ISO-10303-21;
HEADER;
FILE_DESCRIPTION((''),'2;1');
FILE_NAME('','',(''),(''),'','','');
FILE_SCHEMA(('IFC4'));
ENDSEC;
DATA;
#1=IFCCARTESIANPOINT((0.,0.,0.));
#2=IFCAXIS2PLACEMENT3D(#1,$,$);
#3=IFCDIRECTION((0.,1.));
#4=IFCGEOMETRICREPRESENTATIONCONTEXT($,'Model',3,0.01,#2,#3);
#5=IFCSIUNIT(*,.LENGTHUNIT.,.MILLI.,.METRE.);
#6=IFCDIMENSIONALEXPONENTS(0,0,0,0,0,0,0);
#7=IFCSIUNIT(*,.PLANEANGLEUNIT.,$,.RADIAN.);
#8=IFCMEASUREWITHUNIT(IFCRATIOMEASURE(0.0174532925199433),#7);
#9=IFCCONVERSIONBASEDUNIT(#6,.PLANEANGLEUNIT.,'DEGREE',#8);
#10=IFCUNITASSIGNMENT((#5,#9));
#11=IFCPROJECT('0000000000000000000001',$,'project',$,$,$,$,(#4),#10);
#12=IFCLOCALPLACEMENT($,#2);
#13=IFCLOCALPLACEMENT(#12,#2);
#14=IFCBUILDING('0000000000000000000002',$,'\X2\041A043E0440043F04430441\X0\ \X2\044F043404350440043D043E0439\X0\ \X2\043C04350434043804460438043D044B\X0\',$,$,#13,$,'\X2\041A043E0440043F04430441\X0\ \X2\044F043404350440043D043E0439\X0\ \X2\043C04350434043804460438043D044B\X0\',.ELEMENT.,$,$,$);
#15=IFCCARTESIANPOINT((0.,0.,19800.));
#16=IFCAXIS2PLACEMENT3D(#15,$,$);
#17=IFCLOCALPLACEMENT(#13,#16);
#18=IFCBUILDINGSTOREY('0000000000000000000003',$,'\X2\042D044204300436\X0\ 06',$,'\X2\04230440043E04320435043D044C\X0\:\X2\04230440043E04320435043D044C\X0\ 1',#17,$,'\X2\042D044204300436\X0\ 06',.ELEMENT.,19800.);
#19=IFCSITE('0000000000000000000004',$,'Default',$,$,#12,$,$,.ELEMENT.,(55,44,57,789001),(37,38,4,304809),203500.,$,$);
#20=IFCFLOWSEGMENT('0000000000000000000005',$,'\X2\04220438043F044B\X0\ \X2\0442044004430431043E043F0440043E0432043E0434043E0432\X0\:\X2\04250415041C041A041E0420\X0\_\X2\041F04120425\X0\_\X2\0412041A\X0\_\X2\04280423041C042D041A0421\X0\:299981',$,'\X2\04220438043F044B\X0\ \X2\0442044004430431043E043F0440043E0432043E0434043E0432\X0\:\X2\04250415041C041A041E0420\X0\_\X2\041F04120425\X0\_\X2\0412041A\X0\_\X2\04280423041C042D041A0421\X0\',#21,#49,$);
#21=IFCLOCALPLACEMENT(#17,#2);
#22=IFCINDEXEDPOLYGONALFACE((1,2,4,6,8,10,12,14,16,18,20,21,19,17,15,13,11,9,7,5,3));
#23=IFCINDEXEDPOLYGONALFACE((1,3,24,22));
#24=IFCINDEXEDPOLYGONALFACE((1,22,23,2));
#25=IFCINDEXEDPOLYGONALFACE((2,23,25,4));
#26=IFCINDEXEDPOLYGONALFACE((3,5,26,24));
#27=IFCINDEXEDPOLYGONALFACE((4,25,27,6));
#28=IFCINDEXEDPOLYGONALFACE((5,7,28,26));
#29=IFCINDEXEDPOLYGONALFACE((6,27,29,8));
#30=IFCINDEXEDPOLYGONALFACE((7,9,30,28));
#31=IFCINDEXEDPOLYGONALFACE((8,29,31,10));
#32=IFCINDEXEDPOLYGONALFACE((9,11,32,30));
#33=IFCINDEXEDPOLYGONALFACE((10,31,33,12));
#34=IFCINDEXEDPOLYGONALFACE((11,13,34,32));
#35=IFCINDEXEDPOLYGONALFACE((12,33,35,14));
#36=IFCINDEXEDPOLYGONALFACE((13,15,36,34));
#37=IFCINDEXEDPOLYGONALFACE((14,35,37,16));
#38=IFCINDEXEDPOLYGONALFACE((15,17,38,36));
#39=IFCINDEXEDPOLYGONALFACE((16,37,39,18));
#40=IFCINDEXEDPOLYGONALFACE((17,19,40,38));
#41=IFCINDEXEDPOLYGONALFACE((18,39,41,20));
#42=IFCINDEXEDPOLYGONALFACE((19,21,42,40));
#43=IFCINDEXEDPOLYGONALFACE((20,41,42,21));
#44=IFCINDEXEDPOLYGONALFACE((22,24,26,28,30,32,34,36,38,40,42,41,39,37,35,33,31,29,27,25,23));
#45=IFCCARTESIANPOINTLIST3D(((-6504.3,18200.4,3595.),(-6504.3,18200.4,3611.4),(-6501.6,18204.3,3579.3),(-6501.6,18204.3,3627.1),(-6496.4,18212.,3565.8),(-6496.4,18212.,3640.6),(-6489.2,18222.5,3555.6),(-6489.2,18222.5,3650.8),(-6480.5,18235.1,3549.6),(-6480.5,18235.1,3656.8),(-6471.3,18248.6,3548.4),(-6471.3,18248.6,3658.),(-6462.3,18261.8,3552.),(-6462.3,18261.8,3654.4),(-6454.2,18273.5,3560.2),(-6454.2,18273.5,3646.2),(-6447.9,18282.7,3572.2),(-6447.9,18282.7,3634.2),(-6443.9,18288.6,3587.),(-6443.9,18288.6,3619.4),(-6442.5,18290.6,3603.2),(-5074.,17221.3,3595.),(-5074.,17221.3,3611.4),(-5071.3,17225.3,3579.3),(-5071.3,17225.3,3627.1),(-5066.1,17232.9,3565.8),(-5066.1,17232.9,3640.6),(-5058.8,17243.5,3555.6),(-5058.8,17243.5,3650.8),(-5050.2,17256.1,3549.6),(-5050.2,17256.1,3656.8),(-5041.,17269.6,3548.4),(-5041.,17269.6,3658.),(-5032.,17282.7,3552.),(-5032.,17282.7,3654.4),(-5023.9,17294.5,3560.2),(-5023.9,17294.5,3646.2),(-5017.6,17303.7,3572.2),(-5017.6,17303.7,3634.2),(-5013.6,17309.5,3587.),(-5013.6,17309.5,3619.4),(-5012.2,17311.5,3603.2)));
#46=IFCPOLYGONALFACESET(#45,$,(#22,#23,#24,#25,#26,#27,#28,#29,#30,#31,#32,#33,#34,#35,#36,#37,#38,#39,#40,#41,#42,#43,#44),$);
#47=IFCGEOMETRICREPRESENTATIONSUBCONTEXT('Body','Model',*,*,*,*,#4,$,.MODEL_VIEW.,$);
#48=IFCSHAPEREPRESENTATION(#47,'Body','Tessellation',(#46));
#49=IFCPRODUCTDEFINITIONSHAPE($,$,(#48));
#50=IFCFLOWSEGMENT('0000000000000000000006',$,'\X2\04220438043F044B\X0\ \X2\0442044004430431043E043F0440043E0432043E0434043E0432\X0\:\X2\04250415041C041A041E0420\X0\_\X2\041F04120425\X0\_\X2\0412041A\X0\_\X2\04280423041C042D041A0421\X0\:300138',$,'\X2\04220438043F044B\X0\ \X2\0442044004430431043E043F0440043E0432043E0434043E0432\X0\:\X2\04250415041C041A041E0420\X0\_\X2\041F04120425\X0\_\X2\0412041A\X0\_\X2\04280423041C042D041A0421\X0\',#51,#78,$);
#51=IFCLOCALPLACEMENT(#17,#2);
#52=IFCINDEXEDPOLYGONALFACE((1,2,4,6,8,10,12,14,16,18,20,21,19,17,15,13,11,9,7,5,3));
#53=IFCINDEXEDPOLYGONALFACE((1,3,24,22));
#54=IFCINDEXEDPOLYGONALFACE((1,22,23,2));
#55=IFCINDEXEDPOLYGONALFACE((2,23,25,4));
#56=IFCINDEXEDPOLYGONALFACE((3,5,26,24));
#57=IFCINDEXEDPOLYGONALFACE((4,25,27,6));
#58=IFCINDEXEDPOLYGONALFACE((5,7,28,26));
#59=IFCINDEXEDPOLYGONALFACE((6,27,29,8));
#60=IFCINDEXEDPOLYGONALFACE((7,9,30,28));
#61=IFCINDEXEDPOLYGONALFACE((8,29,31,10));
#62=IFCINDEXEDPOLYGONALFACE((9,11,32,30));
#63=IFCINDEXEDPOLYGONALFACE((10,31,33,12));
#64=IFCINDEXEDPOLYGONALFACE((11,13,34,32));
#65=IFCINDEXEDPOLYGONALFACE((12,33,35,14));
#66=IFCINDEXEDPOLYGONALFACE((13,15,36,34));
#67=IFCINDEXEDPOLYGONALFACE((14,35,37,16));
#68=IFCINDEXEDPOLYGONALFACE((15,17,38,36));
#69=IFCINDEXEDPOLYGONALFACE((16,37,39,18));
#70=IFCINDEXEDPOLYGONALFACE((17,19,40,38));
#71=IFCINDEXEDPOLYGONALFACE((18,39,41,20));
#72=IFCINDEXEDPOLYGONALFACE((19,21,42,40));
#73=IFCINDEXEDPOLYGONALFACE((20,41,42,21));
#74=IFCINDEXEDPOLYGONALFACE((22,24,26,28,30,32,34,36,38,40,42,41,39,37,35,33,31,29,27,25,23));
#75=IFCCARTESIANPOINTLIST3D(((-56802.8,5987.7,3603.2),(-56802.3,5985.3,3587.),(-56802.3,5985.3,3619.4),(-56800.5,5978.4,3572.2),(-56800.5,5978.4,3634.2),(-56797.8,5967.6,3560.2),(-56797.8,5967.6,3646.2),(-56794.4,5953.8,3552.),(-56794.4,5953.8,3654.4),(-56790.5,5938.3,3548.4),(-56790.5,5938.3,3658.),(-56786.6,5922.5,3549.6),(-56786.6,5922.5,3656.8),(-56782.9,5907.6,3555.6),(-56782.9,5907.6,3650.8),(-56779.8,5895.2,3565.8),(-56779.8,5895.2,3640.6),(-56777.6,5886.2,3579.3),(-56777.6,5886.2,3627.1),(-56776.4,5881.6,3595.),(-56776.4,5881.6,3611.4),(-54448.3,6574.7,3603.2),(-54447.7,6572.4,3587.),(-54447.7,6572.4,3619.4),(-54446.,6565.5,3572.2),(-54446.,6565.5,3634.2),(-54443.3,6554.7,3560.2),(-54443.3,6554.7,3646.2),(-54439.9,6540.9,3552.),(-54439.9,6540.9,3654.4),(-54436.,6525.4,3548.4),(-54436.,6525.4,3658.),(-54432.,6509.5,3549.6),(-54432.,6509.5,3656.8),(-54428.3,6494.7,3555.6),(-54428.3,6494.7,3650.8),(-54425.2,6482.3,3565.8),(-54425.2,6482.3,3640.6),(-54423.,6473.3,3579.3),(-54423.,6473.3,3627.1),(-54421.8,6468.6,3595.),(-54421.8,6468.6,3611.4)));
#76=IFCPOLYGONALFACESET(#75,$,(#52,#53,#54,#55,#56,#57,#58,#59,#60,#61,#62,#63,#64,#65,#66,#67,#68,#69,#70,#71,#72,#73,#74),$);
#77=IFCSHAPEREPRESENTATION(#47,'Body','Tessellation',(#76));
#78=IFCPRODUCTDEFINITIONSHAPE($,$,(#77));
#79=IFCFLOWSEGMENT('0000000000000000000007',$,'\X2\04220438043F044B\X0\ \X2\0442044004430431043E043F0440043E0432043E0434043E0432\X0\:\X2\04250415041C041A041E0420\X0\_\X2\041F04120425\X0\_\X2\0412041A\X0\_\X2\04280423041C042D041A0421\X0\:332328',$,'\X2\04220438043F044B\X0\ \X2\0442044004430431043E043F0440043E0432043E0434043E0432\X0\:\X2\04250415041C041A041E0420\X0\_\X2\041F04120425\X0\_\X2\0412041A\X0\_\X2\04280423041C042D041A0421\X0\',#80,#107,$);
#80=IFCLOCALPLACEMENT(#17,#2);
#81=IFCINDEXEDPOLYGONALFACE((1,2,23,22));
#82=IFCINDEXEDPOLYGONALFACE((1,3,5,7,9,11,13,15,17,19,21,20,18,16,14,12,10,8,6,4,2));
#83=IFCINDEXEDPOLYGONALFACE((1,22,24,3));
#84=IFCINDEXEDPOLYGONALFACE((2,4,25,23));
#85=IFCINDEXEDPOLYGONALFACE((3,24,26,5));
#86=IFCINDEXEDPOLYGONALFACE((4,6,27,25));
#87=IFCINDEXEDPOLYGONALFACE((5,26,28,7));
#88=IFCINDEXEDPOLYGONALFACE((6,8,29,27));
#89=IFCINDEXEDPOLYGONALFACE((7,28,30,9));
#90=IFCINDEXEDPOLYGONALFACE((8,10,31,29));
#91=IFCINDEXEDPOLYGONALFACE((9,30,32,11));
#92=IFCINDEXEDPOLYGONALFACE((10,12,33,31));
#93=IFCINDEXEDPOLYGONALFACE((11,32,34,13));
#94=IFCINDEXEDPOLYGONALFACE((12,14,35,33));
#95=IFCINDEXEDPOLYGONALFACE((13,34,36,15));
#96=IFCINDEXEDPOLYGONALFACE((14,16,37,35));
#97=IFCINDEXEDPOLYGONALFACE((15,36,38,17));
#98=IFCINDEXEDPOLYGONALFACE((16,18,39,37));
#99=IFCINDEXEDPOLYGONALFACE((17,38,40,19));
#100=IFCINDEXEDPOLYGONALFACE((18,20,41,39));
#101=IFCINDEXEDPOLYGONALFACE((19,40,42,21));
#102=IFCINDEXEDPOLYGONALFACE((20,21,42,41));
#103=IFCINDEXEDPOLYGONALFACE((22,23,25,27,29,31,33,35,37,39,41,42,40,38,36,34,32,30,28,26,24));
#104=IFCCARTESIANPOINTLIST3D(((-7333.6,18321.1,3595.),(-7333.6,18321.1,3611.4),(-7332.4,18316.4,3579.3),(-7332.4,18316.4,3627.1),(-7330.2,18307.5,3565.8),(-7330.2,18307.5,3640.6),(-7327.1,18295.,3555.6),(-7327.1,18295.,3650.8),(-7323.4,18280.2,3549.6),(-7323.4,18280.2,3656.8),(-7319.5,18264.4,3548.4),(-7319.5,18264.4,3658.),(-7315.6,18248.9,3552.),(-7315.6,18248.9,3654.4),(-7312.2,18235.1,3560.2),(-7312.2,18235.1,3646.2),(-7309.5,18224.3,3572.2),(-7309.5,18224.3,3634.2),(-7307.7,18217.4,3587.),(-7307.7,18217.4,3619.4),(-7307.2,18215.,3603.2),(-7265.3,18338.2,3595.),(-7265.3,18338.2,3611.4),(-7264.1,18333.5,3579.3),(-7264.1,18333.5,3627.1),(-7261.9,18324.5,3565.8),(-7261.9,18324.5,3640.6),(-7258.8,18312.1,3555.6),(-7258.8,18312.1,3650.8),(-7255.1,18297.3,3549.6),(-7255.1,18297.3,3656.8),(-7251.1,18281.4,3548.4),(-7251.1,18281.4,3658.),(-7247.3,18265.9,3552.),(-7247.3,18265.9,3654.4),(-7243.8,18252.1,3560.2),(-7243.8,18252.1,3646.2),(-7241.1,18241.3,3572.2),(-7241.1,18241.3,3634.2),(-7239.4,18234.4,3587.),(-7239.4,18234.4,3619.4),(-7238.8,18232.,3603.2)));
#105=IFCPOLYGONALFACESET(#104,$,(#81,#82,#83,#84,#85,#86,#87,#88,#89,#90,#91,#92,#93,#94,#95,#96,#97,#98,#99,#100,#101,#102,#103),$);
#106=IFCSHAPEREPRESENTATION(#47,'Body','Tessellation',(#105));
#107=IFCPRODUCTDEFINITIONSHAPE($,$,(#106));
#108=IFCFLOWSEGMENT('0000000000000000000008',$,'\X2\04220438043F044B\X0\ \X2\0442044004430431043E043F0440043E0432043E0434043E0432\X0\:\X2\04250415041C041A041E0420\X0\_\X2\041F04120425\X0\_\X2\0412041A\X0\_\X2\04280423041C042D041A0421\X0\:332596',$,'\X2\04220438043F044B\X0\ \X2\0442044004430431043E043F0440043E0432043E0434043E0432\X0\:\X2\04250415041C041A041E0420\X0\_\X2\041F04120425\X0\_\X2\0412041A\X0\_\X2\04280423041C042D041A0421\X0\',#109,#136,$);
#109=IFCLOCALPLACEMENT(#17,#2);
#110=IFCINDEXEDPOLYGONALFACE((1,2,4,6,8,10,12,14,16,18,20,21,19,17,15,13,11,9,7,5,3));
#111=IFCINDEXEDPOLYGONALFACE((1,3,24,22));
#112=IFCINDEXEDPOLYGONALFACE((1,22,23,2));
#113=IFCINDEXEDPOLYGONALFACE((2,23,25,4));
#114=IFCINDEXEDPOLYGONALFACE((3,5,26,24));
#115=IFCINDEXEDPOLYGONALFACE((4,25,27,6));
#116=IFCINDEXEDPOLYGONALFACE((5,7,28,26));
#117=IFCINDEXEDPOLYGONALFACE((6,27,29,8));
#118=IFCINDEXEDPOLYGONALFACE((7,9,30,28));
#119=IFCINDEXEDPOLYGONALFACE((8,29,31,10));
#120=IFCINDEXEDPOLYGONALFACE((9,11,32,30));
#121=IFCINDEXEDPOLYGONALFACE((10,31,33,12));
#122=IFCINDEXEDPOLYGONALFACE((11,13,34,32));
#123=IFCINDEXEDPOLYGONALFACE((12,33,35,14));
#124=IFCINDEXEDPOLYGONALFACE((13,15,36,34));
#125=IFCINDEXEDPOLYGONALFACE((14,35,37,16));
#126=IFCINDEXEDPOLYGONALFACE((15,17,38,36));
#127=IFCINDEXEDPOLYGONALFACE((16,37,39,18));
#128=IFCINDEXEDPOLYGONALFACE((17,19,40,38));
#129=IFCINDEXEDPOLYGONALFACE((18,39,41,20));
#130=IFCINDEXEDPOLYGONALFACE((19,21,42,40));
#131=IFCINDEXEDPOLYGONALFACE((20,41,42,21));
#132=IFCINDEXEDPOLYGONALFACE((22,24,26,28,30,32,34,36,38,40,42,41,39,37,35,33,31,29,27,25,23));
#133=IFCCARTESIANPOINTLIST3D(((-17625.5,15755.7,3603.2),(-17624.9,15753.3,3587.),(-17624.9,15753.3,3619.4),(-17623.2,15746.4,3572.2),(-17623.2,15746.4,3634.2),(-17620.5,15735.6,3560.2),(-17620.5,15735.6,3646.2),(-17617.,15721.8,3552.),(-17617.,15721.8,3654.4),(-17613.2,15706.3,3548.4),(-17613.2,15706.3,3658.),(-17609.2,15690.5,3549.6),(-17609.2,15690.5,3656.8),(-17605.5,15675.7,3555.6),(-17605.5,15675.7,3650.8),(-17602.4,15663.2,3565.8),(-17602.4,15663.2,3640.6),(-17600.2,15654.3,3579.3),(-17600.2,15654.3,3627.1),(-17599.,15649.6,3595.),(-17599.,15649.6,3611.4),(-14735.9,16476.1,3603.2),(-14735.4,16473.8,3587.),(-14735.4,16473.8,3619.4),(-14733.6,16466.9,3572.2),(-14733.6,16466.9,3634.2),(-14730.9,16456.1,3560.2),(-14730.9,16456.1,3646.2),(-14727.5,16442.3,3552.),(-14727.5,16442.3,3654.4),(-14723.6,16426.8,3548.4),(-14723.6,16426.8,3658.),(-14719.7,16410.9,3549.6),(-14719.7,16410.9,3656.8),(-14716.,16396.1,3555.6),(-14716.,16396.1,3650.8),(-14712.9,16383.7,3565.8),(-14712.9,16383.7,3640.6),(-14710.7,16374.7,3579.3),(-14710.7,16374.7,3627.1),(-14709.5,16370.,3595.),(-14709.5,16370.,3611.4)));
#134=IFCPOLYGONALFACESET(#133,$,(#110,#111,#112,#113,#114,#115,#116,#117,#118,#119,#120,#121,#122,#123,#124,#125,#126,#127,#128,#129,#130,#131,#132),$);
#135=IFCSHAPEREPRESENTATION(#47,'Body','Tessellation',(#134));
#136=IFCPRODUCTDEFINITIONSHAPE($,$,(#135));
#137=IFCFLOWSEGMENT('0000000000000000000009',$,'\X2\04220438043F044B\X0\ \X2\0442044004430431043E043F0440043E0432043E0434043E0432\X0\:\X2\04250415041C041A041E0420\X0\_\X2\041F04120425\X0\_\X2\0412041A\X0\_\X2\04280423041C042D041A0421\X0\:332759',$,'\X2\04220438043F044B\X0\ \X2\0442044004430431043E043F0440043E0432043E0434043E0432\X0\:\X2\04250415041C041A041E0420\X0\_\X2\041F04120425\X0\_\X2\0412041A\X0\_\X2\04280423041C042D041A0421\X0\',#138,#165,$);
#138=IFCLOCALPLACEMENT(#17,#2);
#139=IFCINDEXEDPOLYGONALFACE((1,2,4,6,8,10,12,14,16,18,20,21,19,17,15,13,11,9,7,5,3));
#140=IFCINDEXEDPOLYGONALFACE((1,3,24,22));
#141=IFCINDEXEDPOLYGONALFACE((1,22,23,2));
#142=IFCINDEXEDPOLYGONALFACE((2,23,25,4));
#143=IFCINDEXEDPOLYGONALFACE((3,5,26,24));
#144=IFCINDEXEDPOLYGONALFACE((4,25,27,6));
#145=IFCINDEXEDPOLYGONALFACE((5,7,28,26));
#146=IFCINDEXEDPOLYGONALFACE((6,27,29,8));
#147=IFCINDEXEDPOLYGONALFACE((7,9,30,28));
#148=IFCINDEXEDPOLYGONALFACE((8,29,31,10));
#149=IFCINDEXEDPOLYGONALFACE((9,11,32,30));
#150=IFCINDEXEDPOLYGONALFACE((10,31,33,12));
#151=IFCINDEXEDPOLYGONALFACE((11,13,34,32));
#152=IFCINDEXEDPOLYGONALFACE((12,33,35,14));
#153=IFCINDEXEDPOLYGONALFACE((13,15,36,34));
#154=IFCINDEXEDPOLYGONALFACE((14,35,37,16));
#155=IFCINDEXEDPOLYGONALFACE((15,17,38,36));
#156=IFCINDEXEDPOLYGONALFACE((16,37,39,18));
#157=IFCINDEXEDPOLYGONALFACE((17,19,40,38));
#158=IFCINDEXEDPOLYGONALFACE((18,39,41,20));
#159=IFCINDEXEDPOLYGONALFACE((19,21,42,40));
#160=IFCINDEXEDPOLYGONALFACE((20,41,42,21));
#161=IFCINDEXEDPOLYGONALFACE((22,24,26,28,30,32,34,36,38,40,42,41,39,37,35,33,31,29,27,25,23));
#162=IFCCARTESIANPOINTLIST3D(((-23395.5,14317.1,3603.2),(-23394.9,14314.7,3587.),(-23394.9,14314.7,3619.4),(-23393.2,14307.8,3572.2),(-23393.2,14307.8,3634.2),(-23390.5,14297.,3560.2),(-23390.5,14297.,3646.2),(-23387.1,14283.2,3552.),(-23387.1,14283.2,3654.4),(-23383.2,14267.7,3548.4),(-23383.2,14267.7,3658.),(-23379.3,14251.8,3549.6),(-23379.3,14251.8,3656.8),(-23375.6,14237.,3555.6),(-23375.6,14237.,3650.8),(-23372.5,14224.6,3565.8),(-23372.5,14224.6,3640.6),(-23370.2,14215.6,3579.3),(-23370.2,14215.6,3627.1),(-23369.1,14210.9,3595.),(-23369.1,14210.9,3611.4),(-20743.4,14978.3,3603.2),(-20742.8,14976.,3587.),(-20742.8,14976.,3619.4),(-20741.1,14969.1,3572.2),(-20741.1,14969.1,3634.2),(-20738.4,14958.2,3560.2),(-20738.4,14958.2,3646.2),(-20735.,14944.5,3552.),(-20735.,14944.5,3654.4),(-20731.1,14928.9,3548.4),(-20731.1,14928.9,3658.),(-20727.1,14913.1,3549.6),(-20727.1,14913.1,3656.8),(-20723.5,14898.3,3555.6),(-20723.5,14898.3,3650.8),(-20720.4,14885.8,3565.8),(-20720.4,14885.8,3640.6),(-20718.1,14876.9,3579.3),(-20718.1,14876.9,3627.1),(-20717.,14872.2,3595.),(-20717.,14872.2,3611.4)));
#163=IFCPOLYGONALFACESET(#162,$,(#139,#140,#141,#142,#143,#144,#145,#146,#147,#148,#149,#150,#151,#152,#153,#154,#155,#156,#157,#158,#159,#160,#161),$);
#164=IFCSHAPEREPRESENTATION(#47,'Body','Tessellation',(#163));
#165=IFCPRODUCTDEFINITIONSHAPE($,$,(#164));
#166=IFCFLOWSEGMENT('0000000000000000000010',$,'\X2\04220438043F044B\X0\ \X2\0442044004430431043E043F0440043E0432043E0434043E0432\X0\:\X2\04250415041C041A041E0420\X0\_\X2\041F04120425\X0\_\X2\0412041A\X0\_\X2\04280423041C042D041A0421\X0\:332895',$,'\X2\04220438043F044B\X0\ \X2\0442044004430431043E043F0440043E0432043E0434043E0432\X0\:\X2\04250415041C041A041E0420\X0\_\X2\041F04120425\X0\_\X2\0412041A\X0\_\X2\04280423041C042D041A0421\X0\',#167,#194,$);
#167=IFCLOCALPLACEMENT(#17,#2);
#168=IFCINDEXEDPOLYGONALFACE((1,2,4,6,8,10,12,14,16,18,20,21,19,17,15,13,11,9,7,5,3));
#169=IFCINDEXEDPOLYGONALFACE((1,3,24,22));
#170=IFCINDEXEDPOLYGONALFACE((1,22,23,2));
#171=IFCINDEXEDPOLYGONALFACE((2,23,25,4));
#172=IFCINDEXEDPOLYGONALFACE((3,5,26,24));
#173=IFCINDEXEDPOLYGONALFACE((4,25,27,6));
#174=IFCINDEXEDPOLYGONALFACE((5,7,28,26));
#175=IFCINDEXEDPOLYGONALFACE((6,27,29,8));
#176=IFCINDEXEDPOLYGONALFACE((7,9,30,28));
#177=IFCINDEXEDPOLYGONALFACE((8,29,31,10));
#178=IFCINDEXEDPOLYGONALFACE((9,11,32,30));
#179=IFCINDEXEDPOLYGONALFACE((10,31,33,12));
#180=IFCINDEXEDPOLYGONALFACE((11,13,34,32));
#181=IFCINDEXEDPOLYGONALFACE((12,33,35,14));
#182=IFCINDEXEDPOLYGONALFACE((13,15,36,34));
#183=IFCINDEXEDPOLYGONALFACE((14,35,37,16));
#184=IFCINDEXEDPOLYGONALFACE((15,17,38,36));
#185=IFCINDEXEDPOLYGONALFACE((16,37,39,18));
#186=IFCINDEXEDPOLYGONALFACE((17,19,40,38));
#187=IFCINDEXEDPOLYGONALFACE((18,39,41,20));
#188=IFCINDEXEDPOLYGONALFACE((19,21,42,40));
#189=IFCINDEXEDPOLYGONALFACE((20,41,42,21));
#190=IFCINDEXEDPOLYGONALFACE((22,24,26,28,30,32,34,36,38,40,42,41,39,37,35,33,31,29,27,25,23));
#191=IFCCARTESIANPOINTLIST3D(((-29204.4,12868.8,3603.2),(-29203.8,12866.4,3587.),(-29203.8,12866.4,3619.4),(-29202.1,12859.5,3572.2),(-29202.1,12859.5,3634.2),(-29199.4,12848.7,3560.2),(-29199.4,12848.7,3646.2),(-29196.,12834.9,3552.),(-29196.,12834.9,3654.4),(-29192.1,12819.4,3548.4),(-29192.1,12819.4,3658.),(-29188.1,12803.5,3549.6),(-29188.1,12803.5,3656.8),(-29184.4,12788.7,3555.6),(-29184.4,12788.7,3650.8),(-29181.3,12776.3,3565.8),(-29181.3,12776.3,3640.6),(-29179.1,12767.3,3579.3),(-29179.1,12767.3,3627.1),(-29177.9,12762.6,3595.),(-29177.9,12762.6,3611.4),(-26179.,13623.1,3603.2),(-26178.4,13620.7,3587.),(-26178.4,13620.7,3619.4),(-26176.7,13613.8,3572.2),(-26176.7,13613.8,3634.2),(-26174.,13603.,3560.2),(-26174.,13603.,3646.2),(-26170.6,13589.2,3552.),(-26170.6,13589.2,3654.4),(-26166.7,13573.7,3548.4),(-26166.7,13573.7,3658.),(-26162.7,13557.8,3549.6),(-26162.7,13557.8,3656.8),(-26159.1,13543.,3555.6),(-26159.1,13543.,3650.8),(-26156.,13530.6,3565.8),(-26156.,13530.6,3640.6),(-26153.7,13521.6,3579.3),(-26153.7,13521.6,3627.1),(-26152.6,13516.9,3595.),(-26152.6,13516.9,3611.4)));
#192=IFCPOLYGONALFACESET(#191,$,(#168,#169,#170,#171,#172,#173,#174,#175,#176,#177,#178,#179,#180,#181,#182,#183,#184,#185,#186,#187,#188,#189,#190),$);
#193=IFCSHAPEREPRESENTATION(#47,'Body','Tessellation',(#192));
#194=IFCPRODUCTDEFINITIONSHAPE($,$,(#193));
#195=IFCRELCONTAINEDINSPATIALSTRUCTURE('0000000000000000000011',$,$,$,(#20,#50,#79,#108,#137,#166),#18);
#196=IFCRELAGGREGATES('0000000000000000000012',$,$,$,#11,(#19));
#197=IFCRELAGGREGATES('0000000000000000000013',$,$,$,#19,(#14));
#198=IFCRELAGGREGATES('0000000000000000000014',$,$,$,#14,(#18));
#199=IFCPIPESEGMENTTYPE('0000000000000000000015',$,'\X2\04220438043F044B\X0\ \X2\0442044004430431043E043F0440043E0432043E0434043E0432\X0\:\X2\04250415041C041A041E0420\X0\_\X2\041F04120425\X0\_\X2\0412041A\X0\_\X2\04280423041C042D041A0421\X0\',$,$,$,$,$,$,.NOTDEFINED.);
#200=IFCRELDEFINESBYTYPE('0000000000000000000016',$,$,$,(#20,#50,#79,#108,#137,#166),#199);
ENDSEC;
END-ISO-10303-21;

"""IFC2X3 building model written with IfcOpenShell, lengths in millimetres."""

from ifc_helpers import new_model, entity, si_unit, converted_unit, direction, frame, origin, origin_2d_with_axis, place, context, subcontext, project, spatial, circle, extrude, type_object, element, save


model = new_model("IFC2X3")

# Units and contexts
model_context = context("Model", 3, precision=0.01, world=origin(), true_north=direction((0.0, 1.0)))
body_context = subcontext(model_context, "Body", "Model", "MODEL_VIEW")
ifc_project = project(units=[si_unit("LENGTHUNIT", "METRE", prefix="MILLI"), converted_unit("PLANEANGLEUNIT", "DEGREE", entity("IfcRatioMeasure", 0.0174532925199433), si_unit("PLANEANGLEUNIT", "RADIAN"), dimensions=[0, 0, 0, 0, 0, 0, 0])], contexts=[model_context])

# Site, building, storey
site_placement = place(None, origin())
site = spatial("IfcSite", under=ifc_project, at=site_placement, Name="Default", CompositionType="ELEMENT", RefLatitude=(55, 44, 57, 789001), RefLongitude=(37, 38, 4, 304809), RefElevation=203500.0)
building_placement = place(site_placement, origin())
building = spatial("IfcBuilding", under=site, at=building_placement, Name="Корпус ядерной медицины", LongName="Корпус ядерной медицины", CompositionType="ELEMENT")
storey_placement = place(building_placement, frame((0.0, 0.0, 19800.0)))
storey = spatial("IfcBuildingStorey", under=building, at=storey_placement, Name="Этаж 06", ObjectType="Уровень:Уровень 1", LongName="Этаж 06", CompositionType="ELEMENT", Elevation=19800.0)

# Flow segments
pipe_segment_type = type_object("IfcPipeSegmentType", Name="Типы трубопроводов:ХЕМКОР_ПВХ_ВК_ШУМЭКС", PredefinedType="NOTDEFINED")
flow_segment_1_placement = place(storey_placement, frame((-6506.3, 17219.2, 3546.6)))
element("IfcFlowSegment", 1, at=flow_segment_1_placement, inside=storey, type_object=pipe_segment_type, Name="Типы трубопроводов:ХЕМКОР_ПВХ_ВК_ШУМЭКС:299981", ObjectType="Типы трубопроводов:ХЕМКОР_ПВХ_ВК_ШУМЭКС", context=body_context, shape_type="SweptSolid", body=[
    extrude(circle(Radius=55.0, at=origin_2d_with_axis()), frame((1463.0, 47.0, 56.6), z_axis=(-0.825187, 0.564859, 0.0), x_axis=(0.564859, 0.825187, 0.0)), (0.0, 0.0, 1.0), 1733.3),
])
flow_segment_2_placement = place(storey_placement, frame((-56804.4, 5879.4, 3546.6)))
element("IfcFlowSegment", 2, at=flow_segment_2_placement, inside=storey, type_object=pipe_segment_type, Name="Типы трубопроводов:ХЕМКОР_ПВХ_ВК_ШУМЭКС:300138", ObjectType="Типы трубопроводов:ХЕМКОР_ПВХ_ВК_ШУМЭКС", context=body_context, shape_type="SweptSolid", body=[
    extrude(circle(Radius=55.0, at=origin_2d_with_axis()), frame((14.9, 55.0, 56.6), z_axis=(0.970296, 0.241922, 0.0), x_axis=(-0.241922, 0.970296, 0.0)), (0.0, 0.0, 1.0), 2426.6),
])
flow_segment_3_placement = place(storey_placement, frame((-7335.4, 18213.4, 3546.6)))
element("IfcFlowSegment", 3, at=flow_segment_3_placement, inside=storey, type_object=pipe_segment_type, Name="Типы трубопроводов:ХЕМКОР_ПВХ_ВК_ШУМЭКС:332328", ObjectType="Типы трубопроводов:ХЕМКОР_ПВХ_ВК_ШУМЭКС", context=body_context, shape_type="SweptSolid", body=[
    extrude(circle(Radius=55.0, at=origin_2d_with_axis()), frame((14.9, 55.0, 56.6), z_axis=(0.970296, 0.241922, 0.0), x_axis=(0.241922, -0.970296, 0.0)), (0.0, 0.0, 1.0), 70.4),
])
flow_segment_4_placement = place(storey_placement, frame((-17627.1, 15647.4, 3546.6)))
element("IfcFlowSegment", 4, at=flow_segment_4_placement, inside=storey, type_object=pipe_segment_type, Name="Типы трубопроводов:ХЕМКОР_ПВХ_ВК_ШУМЭКС:332596", ObjectType="Типы трубопроводов:ХЕМКОР_ПВХ_ВК_ШУМЭКС", context=body_context, shape_type="SweptSolid", body=[
    extrude(circle(Radius=55.0, at=origin_2d_with_axis()), frame((14.9, 55.0, 56.6), z_axis=(0.970296, 0.241922, 0.0), x_axis=(-0.241922, 0.970296, 0.0)), (0.0, 0.0, 1.0), 2978.0),
])
flow_segment_5_placement = place(storey_placement, frame((-23397.1, 14208.8, 3546.6)))
element("IfcFlowSegment", 5, at=flow_segment_5_placement, inside=storey, type_object=pipe_segment_type, Name="Типы трубопроводов:ХЕМКОР_ПВХ_ВК_ШУМЭКС:332759", ObjectType="Типы трубопроводов:ХЕМКОР_ПВХ_ВК_ШУМЭКС", context=body_context, shape_type="SweptSolid", body=[
    extrude(circle(Radius=55.0, at=origin_2d_with_axis()), frame((14.9, 55.0, 56.6), z_axis=(0.970296, 0.241922, 0.0), x_axis=(-0.241922, 0.970296, 0.0)), (0.0, 0.0, 1.0), 2733.3),
])
flow_segment_6_placement = place(storey_placement, frame((-29206.0, 12760.4, 3546.6)))
element("IfcFlowSegment", 6, at=flow_segment_6_placement, inside=storey, type_object=pipe_segment_type, Name="Типы трубопроводов:ХЕМКОР_ПВХ_ВК_ШУМЭКС:332895", ObjectType="Типы трубопроводов:ХЕМКОР_ПВХ_ВК_ШУМЭКС", context=body_context, shape_type="SweptSolid", body=[
    extrude(circle(Radius=55.0, at=origin_2d_with_axis()), frame((14.9, 55.0, 56.6), z_axis=(0.970296, 0.241922, 0.0), x_axis=(-0.241922, 0.970296, 0.0)), (0.0, 0.0, 1.0), 3118.0),
])

save(model, "model.ifc")
